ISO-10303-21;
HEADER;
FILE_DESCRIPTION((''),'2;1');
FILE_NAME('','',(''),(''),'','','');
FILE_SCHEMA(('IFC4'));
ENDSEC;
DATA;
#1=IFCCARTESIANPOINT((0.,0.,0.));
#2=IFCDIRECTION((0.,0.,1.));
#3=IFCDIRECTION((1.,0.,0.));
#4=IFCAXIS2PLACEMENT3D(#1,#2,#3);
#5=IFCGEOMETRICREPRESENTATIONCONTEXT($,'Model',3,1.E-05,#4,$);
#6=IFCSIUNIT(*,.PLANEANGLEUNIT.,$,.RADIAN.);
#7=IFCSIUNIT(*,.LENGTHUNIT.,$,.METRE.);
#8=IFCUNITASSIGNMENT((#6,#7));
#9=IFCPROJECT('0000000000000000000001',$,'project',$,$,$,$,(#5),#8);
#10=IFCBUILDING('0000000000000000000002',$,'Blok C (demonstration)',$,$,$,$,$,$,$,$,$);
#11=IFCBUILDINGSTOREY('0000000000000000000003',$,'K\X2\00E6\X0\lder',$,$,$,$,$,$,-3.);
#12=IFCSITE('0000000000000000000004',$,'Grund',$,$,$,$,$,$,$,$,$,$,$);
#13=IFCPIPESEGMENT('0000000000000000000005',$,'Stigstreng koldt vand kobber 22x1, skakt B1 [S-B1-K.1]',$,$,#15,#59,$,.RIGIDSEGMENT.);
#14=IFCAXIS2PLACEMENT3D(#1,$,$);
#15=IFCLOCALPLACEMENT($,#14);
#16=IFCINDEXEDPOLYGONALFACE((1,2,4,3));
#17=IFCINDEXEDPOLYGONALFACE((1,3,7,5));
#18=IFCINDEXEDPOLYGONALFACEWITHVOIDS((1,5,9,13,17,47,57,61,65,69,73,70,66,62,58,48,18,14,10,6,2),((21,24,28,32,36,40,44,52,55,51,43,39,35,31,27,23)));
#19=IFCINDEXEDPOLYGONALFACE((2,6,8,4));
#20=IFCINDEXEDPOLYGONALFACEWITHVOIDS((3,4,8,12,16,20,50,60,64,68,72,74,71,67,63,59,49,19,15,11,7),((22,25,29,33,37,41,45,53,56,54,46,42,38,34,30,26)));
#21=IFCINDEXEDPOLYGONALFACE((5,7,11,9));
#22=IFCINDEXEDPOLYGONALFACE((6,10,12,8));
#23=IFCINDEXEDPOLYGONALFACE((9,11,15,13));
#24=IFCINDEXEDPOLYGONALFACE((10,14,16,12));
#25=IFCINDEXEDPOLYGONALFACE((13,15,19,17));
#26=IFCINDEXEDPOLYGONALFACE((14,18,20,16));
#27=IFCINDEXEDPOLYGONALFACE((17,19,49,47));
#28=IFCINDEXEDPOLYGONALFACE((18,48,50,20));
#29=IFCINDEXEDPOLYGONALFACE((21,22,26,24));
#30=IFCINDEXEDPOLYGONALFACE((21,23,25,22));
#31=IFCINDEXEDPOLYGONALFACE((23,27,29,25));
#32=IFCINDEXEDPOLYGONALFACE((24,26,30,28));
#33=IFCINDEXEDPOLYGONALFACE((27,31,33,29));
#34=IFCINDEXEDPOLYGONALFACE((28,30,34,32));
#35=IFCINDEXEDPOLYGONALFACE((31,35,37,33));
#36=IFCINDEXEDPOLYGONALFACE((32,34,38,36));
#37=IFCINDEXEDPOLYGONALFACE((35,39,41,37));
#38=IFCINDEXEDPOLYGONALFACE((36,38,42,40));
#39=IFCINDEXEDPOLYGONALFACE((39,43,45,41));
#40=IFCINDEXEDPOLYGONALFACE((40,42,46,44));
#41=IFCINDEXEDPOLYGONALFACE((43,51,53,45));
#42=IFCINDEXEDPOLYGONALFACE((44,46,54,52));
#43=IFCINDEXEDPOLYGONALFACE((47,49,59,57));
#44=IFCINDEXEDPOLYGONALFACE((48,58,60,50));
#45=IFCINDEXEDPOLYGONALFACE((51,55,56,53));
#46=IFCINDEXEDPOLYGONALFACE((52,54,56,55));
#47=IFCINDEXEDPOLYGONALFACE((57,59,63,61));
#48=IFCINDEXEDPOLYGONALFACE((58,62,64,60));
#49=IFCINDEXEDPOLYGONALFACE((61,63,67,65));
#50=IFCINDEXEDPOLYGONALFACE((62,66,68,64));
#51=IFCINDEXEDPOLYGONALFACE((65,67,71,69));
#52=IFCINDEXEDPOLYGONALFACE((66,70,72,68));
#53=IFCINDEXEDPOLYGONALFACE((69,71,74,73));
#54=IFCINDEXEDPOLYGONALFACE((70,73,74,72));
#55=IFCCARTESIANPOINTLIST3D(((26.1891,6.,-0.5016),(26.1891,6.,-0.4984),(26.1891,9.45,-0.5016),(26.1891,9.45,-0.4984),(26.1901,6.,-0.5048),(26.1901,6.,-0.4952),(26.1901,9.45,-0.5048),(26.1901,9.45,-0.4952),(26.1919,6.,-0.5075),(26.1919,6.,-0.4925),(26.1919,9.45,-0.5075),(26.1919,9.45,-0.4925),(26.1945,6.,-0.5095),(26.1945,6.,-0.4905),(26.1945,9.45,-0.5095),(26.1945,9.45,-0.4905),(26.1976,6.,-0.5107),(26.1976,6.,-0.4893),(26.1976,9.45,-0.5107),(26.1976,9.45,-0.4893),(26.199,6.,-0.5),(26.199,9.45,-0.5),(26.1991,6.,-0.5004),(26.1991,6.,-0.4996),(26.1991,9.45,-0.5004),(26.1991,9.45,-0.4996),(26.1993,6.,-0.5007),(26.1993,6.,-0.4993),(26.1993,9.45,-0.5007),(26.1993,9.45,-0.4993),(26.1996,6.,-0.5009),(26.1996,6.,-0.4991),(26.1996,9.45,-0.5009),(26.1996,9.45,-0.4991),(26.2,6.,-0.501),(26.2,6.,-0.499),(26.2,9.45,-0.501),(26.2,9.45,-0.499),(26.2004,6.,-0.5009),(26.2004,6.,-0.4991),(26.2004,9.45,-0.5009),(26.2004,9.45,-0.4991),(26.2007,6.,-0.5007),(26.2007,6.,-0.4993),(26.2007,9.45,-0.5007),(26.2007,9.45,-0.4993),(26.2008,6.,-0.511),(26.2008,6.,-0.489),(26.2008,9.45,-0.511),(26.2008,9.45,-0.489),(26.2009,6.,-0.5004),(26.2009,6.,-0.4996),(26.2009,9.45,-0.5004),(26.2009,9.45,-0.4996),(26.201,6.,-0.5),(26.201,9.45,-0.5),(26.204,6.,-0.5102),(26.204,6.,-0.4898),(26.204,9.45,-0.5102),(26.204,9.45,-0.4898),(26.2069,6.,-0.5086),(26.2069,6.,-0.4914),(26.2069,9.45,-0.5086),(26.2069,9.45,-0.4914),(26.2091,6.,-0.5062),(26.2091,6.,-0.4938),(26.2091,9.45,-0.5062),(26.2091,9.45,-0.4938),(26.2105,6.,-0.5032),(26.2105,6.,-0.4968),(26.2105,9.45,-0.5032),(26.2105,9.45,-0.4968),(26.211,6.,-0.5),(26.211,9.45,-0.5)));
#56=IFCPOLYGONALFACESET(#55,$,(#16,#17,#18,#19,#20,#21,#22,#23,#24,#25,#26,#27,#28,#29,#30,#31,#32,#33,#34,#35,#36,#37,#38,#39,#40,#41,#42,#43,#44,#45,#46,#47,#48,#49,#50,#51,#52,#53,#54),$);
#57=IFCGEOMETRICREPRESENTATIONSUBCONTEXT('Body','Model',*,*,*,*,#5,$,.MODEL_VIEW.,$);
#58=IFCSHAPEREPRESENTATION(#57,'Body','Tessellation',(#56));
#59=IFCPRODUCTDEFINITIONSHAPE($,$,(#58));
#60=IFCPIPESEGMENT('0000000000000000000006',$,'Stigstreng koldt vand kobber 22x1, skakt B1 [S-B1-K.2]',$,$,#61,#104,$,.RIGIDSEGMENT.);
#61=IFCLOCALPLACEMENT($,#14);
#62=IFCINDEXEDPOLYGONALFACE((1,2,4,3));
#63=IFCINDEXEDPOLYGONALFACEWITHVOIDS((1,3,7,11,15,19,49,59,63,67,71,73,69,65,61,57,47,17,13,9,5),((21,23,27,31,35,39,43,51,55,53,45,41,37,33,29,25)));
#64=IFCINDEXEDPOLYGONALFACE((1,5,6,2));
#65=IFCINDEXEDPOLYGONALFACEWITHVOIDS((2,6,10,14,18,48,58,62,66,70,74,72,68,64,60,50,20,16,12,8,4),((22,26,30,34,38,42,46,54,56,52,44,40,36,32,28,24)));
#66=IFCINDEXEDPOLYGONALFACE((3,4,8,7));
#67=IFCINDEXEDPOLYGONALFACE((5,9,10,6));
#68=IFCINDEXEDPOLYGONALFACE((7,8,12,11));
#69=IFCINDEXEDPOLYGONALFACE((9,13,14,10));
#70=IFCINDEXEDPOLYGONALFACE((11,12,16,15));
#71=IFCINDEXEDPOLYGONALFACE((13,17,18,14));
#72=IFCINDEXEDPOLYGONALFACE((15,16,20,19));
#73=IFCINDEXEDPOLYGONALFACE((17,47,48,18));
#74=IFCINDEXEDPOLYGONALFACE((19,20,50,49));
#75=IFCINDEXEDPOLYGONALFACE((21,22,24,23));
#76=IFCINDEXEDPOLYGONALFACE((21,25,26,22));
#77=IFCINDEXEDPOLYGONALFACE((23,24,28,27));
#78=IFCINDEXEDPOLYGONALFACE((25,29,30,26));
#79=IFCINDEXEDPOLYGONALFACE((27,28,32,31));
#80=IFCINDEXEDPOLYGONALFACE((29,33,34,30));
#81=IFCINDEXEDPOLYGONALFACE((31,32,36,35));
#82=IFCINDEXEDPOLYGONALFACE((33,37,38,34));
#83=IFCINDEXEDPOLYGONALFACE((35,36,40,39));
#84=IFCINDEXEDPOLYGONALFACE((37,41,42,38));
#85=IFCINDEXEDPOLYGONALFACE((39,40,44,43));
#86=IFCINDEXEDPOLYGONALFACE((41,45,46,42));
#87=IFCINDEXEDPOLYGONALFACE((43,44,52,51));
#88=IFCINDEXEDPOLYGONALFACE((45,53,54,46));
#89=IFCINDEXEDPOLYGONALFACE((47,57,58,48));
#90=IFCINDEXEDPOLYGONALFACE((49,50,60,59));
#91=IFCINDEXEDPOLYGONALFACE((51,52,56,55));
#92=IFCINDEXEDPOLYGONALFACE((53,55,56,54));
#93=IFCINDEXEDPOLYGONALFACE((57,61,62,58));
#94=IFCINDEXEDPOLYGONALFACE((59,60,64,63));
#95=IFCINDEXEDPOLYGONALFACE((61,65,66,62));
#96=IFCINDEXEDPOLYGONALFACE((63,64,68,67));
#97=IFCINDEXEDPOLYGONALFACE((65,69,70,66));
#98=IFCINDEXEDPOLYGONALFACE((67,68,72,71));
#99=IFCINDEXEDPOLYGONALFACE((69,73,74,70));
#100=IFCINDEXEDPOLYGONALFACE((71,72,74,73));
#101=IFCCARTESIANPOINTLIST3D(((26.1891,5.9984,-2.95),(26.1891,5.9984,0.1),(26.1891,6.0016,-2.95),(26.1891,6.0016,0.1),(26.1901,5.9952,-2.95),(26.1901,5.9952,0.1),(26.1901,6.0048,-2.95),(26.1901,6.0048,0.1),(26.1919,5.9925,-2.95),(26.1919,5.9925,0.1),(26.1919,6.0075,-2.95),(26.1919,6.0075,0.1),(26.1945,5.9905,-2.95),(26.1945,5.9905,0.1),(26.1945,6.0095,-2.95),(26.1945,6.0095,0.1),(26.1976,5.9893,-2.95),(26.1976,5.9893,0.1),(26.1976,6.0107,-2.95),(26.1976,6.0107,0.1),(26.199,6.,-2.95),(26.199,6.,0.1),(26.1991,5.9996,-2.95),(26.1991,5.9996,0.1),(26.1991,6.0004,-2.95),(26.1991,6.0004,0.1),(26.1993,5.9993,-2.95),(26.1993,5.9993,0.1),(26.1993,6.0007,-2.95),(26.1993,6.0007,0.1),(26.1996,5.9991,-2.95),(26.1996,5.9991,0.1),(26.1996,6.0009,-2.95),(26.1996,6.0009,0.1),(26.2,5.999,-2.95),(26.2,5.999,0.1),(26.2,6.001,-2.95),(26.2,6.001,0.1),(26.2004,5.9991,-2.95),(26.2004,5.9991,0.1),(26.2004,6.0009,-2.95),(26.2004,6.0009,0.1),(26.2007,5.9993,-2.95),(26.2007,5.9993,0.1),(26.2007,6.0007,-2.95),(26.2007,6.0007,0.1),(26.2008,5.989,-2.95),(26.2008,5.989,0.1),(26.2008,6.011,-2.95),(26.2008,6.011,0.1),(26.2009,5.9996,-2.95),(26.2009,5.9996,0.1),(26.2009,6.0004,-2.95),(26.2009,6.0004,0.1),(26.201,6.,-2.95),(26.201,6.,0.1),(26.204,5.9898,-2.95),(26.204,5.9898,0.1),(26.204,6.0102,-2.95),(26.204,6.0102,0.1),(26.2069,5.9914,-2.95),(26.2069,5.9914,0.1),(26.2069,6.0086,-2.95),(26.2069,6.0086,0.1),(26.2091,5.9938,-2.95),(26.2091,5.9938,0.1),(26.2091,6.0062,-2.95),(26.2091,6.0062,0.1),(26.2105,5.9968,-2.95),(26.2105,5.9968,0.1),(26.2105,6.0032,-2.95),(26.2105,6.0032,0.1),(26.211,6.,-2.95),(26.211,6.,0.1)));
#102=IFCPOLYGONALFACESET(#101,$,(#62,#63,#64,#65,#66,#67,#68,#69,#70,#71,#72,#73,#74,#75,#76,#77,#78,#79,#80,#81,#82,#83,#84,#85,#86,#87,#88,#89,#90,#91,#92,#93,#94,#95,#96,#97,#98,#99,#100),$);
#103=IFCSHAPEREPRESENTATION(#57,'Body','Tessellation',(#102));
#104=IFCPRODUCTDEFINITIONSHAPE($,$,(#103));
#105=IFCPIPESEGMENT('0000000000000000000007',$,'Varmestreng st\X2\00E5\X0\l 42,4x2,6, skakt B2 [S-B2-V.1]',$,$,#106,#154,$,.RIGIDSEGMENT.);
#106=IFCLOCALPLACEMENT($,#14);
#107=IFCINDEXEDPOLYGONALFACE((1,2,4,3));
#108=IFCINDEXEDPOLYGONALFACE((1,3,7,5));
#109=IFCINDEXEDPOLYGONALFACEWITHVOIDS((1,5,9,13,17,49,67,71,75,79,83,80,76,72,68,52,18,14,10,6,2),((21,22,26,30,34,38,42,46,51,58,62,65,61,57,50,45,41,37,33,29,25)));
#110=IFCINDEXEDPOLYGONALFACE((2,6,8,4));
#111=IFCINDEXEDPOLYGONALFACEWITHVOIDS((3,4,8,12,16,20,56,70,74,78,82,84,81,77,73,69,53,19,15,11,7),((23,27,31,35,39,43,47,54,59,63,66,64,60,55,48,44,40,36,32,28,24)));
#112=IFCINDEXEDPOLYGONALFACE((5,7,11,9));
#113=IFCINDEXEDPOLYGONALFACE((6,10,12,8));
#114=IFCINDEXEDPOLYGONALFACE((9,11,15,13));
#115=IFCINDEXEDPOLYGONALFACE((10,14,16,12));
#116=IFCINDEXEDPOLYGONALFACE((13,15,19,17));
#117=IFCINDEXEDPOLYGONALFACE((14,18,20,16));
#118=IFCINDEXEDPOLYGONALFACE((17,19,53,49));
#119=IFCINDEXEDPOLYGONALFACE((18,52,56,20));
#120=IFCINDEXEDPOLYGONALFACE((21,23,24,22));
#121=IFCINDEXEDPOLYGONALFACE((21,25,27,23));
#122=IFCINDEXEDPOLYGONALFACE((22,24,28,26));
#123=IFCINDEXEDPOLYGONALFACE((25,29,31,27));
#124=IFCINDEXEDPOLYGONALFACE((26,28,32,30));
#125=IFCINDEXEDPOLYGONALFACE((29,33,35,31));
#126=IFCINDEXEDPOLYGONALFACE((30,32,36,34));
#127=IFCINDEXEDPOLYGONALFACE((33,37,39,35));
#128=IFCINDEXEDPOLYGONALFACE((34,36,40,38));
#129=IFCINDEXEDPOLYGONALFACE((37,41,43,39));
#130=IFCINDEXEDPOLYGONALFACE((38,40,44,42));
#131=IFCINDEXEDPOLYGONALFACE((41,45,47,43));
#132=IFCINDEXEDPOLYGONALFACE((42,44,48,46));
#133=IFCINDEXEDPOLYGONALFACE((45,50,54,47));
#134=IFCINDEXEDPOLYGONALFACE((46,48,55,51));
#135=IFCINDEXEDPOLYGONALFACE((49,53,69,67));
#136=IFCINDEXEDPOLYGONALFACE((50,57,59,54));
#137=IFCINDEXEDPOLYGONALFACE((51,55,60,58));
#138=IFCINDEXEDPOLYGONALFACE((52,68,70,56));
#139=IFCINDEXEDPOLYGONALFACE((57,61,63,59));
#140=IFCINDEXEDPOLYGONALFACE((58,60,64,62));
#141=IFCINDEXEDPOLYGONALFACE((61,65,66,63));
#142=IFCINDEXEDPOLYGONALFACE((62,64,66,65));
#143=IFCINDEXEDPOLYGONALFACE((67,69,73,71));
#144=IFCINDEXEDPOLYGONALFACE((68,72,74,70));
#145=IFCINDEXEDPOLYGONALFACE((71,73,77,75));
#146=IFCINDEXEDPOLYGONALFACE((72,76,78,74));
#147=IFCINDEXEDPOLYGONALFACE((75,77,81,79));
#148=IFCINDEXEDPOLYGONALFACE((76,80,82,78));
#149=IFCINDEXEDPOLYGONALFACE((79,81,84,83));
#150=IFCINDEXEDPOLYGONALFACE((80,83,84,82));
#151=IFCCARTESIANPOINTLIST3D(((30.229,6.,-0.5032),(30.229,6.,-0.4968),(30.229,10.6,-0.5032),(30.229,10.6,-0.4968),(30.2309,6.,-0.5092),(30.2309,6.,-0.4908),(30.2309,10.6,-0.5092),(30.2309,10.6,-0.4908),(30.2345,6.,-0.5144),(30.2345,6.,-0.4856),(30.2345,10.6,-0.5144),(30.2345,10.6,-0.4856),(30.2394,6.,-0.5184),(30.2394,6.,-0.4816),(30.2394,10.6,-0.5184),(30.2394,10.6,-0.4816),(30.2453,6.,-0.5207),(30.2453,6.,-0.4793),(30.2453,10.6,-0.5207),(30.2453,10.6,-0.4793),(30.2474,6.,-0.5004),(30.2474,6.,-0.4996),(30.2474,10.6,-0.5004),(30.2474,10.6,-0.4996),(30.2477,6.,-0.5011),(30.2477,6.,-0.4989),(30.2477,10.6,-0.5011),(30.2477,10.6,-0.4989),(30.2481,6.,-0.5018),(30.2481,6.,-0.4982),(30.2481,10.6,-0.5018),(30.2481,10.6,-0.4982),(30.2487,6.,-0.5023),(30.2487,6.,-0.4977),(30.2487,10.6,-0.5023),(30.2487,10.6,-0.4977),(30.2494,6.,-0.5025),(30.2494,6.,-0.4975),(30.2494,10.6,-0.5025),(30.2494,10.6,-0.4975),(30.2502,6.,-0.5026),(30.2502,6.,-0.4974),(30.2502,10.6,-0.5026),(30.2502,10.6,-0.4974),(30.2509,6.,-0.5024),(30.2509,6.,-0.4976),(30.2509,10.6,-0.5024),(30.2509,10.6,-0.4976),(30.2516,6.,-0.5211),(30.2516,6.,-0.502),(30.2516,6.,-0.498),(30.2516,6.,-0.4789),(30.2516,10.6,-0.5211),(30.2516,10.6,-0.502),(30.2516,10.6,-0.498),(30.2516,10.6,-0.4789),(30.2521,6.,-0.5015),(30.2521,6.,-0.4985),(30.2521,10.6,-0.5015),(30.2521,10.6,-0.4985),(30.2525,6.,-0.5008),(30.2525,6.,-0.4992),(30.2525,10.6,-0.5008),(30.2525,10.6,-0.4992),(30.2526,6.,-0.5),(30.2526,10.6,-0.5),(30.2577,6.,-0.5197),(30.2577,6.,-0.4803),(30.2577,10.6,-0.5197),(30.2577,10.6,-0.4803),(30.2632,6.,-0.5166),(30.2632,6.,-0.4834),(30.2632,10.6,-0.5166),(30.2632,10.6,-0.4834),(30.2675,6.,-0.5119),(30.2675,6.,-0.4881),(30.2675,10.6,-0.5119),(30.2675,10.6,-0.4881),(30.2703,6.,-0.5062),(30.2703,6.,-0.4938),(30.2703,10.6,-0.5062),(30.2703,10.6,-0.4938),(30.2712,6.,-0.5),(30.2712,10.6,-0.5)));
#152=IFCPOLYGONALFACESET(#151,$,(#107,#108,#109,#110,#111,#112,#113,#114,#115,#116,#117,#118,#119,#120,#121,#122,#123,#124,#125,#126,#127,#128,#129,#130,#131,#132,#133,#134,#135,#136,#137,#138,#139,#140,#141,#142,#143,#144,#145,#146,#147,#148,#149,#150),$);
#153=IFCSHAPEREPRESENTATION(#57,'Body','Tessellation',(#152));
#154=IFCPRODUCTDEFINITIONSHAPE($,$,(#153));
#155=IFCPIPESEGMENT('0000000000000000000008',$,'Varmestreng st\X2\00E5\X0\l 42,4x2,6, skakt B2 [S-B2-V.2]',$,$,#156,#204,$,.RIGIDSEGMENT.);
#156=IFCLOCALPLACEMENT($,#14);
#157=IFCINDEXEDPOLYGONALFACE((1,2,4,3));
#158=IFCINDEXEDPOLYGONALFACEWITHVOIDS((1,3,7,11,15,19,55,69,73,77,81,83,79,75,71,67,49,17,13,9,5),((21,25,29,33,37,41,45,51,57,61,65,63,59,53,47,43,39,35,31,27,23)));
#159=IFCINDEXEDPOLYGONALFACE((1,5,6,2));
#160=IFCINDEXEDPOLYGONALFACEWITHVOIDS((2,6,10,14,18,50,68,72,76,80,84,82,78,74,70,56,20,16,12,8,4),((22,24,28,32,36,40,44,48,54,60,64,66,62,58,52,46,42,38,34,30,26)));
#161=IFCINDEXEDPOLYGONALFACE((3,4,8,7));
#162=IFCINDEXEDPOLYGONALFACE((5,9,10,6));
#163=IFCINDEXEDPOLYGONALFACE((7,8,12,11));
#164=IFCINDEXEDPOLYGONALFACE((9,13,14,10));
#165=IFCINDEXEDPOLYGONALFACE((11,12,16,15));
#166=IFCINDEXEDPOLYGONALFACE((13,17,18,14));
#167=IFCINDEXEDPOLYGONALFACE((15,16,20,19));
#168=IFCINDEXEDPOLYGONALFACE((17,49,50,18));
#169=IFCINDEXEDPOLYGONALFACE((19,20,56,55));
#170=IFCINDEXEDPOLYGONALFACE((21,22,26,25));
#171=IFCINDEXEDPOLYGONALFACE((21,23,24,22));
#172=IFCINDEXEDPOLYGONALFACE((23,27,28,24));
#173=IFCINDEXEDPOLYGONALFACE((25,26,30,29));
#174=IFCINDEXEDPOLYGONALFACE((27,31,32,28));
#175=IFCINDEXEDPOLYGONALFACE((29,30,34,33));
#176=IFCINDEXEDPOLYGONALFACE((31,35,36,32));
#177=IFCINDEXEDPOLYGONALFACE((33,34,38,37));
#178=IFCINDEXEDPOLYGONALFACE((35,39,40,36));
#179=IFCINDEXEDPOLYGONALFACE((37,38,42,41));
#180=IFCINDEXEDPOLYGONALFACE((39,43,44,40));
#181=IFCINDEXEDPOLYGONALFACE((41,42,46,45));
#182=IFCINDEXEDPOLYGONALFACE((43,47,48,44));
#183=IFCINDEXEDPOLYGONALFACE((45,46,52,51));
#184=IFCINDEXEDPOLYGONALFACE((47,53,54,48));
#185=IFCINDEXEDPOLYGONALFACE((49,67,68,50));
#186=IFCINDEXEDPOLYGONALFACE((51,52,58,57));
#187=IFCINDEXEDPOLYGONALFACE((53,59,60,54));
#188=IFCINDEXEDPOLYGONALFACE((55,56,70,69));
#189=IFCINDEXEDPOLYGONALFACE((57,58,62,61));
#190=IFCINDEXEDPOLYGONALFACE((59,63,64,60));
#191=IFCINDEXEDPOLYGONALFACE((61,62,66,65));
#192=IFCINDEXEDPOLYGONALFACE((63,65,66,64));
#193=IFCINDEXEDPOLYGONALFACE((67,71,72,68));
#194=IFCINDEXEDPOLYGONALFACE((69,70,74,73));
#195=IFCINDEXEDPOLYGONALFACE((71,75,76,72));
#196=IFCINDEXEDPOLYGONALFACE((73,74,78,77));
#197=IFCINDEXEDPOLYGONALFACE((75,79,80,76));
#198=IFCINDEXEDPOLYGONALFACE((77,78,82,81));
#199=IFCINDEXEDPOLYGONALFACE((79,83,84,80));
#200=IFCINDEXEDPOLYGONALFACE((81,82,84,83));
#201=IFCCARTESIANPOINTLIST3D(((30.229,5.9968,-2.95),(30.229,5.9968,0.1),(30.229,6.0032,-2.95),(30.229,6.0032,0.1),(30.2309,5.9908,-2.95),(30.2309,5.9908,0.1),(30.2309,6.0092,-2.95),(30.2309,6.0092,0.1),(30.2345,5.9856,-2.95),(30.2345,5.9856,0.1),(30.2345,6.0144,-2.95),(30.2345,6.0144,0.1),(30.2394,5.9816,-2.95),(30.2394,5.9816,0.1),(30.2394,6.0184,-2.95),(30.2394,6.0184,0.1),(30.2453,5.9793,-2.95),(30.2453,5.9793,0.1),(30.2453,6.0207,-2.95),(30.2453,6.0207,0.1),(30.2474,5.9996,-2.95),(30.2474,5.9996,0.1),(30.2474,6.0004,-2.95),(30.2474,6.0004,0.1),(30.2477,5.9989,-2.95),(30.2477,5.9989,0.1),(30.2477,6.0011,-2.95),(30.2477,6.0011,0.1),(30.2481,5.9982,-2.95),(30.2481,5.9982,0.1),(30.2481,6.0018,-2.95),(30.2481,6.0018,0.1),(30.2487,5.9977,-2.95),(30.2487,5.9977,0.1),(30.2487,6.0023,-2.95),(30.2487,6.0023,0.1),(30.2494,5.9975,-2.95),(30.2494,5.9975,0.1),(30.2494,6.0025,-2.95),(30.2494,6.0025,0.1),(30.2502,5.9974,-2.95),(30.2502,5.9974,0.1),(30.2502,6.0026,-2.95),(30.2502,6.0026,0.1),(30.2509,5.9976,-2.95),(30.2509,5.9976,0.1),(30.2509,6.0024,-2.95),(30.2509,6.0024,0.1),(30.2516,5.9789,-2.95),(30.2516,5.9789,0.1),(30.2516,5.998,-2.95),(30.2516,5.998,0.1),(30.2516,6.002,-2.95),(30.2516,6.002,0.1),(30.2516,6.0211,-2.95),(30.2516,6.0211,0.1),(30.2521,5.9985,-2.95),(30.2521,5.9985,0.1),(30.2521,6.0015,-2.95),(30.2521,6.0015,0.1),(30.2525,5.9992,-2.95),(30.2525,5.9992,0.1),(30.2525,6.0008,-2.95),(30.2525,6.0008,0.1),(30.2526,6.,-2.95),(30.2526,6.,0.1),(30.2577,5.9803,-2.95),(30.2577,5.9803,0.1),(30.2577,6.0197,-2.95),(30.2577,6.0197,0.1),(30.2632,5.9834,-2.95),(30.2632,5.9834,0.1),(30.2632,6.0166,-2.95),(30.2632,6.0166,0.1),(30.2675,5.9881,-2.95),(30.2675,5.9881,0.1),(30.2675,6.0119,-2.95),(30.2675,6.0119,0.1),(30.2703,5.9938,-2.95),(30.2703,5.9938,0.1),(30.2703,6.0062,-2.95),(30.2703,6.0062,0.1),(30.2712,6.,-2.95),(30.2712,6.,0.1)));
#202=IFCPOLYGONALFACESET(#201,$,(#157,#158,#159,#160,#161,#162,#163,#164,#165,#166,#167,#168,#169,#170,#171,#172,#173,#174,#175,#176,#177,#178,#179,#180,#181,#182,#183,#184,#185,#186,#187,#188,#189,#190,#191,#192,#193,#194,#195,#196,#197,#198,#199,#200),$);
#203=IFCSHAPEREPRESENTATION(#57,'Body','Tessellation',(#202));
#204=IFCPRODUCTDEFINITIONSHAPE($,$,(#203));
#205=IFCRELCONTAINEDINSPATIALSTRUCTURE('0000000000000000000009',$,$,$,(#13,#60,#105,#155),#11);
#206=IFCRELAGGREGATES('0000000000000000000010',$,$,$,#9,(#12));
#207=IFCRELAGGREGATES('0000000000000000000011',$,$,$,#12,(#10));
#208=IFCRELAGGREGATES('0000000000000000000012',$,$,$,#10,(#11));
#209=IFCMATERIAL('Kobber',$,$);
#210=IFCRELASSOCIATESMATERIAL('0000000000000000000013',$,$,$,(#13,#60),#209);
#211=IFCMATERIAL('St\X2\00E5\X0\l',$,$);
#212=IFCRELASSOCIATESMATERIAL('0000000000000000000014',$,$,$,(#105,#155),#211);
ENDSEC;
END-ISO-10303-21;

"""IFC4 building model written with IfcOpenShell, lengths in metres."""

from ifc_helpers import new_model, si_unit, frame, origin_with_axes, place, context, subcontext, project, spatial, hollow_circle, extrude, material, element, save


model = new_model("IFC4")

# Units and contexts
model_context = context("Model", 3, precision=1e-05, world=origin_with_axes())
body_context = subcontext(model_context, "Body", "Model", "MODEL_VIEW")
ifc_project = project(units=[si_unit("PLANEANGLEUNIT", "RADIAN"), si_unit("LENGTHUNIT", "METRE")], contexts=[model_context])

# Site, building, storey
site = spatial("IfcSite", under=ifc_project, Name="Grund")
building = spatial("IfcBuilding", under=site, Name="Blok C (demonstration)")
storey = spatial("IfcBuildingStorey", under=building, Name="Kælder", Elevation=-3.0)

# Pipe segments
ifc_material_1 = material(Name="Stål")
ifc_material_2 = material(Name="Kobber")
pipe_segment_1_placement = place(None, origin_with_axes())
element("IfcPipeSegment", 1, at=pipe_segment_1_placement, inside=storey, material=ifc_material_2, Name="Stigstreng koldt vand kobber 22x1, skakt B1 [S-B1-K.1]", PredefinedType="RIGIDSEGMENT", context=body_context, shape_type="SweptSolid", body=[
    extrude(hollow_circle(Radius=0.011, WallThickness=0.01), frame((26.2, 9.45, -0.5), z_axis=(0.0, -1.0, 0.0), x_axis=(1.0, 0.0, 0.0)), (0.0, 0.0, 1.0), 3.45),
])
pipe_segment_2_placement = place(None, origin_with_axes())
element("IfcPipeSegment", 2, at=pipe_segment_2_placement, inside=storey, material=ifc_material_2, Name="Stigstreng koldt vand kobber 22x1, skakt B1 [S-B1-K.2]", PredefinedType="RIGIDSEGMENT", context=body_context, shape_type="SweptSolid", body=[
    extrude(hollow_circle(Radius=0.011, WallThickness=0.01), frame((26.2, 6.0, -2.95), z_axis=(0.0, 0.0, 1.0), x_axis=(1.0, 0.0, 0.0)), (0.0, 0.0, 1.0), 3.05),
])
pipe_segment_3_placement = place(None, origin_with_axes())
element("IfcPipeSegment", 3, at=pipe_segment_3_placement, inside=storey, material=ifc_material_1, Name="Varmestreng stål 42,4x2,6, skakt B2 [S-B2-V.1]", PredefinedType="RIGIDSEGMENT", context=body_context, shape_type="SweptSolid", body=[
    extrude(hollow_circle(Radius=0.0212, WallThickness=0.0186), frame((30.25, 10.6, -0.5), z_axis=(0.0, -1.0, 0.0), x_axis=(1.0, 0.0, 0.0)), (0.0, 0.0, 1.0), 4.6),
])
pipe_segment_4_placement = place(None, origin_with_axes())
element("IfcPipeSegment", 4, at=pipe_segment_4_placement, inside=storey, material=ifc_material_1, Name="Varmestreng stål 42,4x2,6, skakt B2 [S-B2-V.2]", PredefinedType="RIGIDSEGMENT", context=body_context, shape_type="SweptSolid", body=[
    extrude(hollow_circle(Radius=0.0212, WallThickness=0.0186), frame((30.25, 6.0, -2.95), z_axis=(0.0, 0.0, 1.0), x_axis=(1.0, 0.0, 0.0)), (0.0, 0.0, 1.0), 3.05),
])

save(model, "model.ifc")
